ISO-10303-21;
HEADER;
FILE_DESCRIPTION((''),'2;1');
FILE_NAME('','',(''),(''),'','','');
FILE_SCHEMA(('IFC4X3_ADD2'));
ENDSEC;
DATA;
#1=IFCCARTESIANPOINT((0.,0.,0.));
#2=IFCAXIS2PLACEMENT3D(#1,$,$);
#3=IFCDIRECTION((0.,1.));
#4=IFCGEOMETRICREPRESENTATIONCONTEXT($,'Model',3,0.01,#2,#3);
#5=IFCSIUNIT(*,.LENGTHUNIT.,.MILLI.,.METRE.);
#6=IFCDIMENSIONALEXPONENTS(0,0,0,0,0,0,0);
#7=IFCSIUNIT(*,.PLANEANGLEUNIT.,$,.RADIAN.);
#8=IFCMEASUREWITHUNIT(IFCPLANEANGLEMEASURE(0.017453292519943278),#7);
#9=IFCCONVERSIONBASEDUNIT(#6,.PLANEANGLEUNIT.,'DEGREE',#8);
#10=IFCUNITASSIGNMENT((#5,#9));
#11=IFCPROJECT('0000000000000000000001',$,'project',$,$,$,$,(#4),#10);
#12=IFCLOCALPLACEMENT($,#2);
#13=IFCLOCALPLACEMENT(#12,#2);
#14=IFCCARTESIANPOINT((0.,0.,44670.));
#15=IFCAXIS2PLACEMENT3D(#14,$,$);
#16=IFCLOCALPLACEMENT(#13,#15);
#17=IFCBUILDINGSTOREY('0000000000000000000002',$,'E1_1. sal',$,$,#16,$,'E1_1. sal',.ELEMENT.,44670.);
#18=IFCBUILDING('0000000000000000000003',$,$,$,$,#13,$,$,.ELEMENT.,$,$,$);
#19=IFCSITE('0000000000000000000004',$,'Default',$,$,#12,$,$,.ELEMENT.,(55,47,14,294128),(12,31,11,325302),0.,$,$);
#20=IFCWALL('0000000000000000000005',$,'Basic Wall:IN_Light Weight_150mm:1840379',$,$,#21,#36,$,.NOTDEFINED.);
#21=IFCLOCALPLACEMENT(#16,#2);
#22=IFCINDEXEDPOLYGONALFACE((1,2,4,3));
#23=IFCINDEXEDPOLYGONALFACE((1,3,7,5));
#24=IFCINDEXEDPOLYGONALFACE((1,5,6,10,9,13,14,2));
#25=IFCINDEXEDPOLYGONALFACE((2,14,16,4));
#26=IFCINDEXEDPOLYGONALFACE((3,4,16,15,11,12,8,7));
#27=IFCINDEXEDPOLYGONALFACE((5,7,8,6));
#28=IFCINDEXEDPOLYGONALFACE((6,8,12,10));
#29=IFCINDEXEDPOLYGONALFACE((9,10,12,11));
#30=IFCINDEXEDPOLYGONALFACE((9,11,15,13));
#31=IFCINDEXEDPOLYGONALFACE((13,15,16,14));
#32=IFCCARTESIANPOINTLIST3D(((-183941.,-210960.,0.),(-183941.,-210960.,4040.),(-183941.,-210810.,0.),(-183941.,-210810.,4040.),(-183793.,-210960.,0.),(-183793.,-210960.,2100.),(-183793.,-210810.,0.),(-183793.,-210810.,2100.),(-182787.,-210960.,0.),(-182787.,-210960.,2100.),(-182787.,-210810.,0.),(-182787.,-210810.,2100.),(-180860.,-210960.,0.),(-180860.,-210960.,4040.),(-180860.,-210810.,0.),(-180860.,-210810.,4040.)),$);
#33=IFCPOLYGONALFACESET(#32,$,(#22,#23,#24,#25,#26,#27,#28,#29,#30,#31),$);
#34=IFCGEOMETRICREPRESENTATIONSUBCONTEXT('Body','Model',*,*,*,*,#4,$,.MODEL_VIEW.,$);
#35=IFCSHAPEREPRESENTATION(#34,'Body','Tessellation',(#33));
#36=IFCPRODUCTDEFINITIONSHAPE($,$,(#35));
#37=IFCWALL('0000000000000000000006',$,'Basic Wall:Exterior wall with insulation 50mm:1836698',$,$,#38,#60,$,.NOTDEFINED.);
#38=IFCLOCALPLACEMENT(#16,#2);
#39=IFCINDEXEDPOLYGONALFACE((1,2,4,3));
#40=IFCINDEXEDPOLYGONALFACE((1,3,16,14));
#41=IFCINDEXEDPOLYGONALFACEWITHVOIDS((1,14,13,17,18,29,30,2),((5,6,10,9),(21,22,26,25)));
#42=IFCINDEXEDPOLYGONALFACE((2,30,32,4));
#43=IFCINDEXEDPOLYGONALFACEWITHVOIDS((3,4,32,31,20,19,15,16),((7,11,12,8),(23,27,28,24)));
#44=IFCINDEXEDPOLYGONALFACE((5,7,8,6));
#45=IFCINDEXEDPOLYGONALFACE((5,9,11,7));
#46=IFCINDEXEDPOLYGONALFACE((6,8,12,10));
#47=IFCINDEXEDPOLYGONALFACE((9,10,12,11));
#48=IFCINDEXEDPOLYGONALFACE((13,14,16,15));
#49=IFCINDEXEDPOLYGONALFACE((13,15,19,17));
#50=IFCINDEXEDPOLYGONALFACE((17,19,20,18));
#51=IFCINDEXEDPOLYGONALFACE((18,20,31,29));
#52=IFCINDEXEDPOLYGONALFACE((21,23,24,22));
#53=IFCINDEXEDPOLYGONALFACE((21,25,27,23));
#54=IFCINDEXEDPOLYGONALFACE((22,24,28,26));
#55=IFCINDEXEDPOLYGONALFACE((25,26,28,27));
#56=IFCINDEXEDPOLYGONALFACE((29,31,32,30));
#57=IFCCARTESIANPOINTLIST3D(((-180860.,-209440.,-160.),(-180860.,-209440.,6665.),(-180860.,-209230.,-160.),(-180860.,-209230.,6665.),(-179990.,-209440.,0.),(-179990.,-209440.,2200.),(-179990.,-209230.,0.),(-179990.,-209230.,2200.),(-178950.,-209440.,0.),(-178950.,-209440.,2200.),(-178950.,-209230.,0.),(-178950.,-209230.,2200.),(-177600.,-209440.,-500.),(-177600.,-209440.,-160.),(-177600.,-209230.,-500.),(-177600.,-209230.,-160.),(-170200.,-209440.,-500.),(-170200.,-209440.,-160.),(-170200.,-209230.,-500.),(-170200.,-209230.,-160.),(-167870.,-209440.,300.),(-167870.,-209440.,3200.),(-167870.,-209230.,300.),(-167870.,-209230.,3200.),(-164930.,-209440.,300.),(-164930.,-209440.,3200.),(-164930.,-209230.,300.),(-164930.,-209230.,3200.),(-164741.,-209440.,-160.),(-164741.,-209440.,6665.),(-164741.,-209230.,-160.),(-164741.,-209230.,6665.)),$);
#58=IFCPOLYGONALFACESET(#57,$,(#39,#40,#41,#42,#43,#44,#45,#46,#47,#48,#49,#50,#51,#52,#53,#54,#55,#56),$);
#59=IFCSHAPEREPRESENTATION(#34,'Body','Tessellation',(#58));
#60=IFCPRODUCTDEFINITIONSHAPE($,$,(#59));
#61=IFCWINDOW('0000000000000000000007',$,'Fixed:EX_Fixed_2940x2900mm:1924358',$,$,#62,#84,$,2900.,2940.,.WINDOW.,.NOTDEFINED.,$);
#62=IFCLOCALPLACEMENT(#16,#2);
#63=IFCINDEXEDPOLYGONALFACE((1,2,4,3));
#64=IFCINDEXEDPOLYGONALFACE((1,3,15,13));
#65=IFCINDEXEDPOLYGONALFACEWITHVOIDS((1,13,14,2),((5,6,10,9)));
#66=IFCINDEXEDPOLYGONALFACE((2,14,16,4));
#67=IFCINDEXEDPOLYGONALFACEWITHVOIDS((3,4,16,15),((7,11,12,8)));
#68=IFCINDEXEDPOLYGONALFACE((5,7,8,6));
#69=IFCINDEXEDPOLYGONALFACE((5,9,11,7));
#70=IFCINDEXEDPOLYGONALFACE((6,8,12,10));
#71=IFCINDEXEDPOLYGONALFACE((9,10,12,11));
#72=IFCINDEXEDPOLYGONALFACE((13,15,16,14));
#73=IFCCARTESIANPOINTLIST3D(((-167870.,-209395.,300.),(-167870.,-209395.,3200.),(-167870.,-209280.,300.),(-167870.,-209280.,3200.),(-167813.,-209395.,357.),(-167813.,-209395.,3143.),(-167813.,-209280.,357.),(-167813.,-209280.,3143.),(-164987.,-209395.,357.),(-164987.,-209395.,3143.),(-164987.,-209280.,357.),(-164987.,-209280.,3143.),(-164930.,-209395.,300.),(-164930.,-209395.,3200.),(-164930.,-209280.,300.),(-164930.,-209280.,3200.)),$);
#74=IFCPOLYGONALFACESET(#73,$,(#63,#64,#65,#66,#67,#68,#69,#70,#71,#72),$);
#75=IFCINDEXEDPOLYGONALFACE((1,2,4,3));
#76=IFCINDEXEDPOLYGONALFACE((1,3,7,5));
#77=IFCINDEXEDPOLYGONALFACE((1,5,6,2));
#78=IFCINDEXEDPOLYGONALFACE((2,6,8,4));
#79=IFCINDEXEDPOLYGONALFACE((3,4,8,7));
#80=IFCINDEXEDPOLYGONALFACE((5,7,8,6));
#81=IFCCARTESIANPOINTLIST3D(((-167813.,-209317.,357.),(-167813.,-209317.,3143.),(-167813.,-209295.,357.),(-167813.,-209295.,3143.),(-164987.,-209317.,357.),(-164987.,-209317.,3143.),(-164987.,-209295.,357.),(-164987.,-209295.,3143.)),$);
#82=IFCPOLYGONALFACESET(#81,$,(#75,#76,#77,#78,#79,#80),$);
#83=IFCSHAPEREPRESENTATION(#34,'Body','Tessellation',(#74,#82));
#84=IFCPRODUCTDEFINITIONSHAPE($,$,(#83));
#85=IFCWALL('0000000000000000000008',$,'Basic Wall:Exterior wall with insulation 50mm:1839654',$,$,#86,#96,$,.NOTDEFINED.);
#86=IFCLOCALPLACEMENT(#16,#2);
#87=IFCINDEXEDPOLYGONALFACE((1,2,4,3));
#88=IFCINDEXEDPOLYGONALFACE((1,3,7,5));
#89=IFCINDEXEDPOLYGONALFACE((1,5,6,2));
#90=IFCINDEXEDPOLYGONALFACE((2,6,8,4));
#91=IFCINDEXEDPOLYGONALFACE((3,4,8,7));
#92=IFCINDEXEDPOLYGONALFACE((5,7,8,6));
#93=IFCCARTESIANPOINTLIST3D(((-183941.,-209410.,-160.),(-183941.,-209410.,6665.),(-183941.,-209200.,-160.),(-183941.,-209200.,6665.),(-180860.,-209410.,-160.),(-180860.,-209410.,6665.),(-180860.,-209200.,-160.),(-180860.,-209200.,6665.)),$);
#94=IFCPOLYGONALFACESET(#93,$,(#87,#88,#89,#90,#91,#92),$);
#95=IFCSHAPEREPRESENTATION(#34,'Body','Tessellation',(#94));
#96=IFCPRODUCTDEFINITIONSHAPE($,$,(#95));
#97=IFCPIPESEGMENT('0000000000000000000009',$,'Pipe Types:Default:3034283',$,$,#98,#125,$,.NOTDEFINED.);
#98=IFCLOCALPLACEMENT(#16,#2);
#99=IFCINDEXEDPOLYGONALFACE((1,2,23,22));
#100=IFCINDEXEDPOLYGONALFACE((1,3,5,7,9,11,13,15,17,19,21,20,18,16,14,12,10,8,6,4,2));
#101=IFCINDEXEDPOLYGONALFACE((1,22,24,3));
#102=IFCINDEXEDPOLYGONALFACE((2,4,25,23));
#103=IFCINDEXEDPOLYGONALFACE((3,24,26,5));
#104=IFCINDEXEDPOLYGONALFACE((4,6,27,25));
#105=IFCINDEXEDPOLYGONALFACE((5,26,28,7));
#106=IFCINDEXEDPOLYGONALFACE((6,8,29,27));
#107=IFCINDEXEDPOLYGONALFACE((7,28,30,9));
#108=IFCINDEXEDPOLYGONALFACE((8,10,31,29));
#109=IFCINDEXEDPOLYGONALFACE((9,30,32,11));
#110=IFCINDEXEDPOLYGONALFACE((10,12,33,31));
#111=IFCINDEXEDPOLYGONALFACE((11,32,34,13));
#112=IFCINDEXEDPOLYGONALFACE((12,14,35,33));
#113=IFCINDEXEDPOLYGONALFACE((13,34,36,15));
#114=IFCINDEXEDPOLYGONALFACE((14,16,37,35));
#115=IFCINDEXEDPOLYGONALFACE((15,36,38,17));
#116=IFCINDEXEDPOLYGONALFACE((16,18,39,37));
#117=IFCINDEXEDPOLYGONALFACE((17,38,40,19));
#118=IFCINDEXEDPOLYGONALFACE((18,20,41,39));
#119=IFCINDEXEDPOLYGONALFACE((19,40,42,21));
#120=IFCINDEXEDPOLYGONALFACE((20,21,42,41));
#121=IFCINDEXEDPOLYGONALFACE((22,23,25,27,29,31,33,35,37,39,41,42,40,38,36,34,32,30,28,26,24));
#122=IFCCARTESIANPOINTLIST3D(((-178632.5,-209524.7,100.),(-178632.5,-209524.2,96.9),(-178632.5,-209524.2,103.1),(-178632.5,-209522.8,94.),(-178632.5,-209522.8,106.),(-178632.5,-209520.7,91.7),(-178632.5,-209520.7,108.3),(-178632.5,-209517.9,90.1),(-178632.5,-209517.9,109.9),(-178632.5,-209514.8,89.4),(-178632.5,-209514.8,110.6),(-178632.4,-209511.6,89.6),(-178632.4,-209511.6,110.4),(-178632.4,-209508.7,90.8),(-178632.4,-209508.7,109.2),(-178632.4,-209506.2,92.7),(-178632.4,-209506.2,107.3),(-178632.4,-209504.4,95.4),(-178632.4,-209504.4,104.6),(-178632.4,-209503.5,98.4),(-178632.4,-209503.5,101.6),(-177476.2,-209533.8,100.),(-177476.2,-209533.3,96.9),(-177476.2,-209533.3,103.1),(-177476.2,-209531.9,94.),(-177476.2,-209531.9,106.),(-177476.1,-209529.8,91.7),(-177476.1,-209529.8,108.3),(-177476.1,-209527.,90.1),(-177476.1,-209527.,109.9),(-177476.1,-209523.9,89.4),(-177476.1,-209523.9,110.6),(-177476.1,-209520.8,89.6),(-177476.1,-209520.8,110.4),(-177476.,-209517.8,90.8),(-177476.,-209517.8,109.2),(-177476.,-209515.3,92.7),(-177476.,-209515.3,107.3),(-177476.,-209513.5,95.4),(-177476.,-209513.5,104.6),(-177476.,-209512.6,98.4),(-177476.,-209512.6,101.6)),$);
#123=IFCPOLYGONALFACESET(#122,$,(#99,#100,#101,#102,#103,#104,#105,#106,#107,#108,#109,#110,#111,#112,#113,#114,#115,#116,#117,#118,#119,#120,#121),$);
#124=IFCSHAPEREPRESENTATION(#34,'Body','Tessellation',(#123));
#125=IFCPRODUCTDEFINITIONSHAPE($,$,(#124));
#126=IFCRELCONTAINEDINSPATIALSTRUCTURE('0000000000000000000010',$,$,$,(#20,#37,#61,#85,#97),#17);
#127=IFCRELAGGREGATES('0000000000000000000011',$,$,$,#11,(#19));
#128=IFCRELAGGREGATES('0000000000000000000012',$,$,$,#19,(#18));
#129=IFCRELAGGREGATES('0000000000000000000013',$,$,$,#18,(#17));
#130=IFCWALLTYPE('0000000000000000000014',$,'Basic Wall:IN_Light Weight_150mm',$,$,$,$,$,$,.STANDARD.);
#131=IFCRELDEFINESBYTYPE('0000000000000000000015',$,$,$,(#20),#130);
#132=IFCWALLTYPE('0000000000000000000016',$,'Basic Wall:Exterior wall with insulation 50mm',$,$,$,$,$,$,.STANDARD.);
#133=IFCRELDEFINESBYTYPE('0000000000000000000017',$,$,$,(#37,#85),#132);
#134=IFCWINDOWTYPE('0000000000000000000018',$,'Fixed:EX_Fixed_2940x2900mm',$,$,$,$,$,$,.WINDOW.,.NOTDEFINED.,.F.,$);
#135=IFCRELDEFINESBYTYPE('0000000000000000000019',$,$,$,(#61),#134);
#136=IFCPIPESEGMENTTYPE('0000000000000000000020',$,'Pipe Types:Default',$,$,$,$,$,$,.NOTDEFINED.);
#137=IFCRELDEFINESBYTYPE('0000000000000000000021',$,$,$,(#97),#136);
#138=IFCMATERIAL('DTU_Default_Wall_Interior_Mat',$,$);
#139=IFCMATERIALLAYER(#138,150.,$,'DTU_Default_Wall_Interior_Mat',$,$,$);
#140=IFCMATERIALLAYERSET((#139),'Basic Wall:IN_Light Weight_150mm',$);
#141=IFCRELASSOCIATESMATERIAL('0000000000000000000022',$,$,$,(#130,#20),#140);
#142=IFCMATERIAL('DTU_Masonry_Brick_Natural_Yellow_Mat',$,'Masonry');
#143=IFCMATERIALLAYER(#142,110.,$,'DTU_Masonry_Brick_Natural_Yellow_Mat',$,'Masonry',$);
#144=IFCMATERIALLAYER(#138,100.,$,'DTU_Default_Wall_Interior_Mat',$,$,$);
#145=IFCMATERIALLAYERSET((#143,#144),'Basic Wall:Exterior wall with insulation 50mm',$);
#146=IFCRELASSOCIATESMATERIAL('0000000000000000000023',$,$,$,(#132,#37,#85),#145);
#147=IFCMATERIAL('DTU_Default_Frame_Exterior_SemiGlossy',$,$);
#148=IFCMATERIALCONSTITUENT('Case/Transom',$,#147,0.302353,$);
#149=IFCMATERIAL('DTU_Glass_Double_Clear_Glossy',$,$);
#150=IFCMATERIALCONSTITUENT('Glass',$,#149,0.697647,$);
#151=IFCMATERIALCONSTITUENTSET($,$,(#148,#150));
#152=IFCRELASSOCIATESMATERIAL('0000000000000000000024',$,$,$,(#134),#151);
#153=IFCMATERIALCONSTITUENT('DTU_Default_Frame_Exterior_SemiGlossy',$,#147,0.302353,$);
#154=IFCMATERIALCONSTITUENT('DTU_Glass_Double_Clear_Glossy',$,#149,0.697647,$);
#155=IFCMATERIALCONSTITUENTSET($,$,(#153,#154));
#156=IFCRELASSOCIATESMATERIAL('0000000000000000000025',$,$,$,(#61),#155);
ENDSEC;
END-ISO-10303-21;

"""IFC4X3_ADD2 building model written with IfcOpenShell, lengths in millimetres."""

from ifc_helpers import new_model, entity, si_unit, converted_unit, direction, frame, frame_2d, origin, place, context, subcontext, project, spatial, polyline, rectangle, circle, outline, extrude, source, transform, mapped, material, layer, layer_set, constituent, constituent_set, type_object, type_shapes, element, fill, save


model = new_model("IFC4X3_ADD2")

# Units and contexts
model_context = context("Model", 3, precision=0.01, world=origin(), true_north=direction((0.0, 1.0)))
body_context = subcontext(model_context, "Body", "Model", "MODEL_VIEW")
ifc_project = project(units=[si_unit("LENGTHUNIT", "METRE", prefix="MILLI"), converted_unit("PLANEANGLEUNIT", "DEGREE", entity("IfcPlaneAngleMeasure", 0.017453292519943278), si_unit("PLANEANGLEUNIT", "RADIAN"), dimensions=[0, 0, 0, 0, 0, 0, 0])], contexts=[model_context])

# Site, building, storey
site_placement = place(None, origin())
site = spatial("IfcSite", under=ifc_project, at=site_placement, Name="Default", CompositionType="ELEMENT", RefLatitude=(55, 47, 14, 294128), RefLongitude=(12, 31, 11, 325302), RefElevation=0.0)
building_placement = place(site_placement, origin())
building = spatial("IfcBuilding", under=site, at=building_placement, CompositionType="ELEMENT")
storey_placement = place(building_placement, frame((0.0, 0.0, 44670.0)))
storey = spatial("IfcBuildingStorey", under=building, at=storey_placement, Name="E1_1. sal", LongName="E1_1. sal", CompositionType="ELEMENT", Elevation=44670.0)

# Wall, opening
ifc_material_1 = material(Name="DTU_Default_Wall_Interior_Mat")
ifc_layer_1 = layer(ifc_material_1, 150.0, Name="DTU_Default_Wall_Interior_Mat")
ifc_layer_set_1 = layer_set([ifc_layer_1], Name="Basic Wall:IN_Light Weight_150mm")
wall_type_1 = type_object("IfcWallType", Name="Basic Wall:IN_Light Weight_150mm", PredefinedType="STANDARD", material=ifc_layer_set_1)
wall_1_placement = place(storey_placement, frame((-183941.0, -210885.0, 0.0)))
wall_1 = element("IfcWall", 1, at=wall_1_placement, inside=storey, type_object=wall_type_1, material=ifc_layer_set_1, Name="Basic Wall:IN_Light Weight_150mm:1840379", PredefinedType="NOTDEFINED", context=body_context, shape_type="SweptSolid", body=[
    extrude(rectangle(XDim=3081.0, YDim=150.0, at=frame_2d((1540.5, 0.0), x_axis=(1.0, 0.0))), origin(), (0.0, 0.0, 1.0), 4040.0),
])
opening_1_placement = place(wall_1_placement, frame((1154.0, 75.0, 0.0)))
element("IfcOpeningElement", 2, at=opening_1_placement, cuts=wall_1, PredefinedType="OPENING", context=body_context, shape_type="SweptSolid", body=[
    extrude(rectangle(XDim=2100.0, YDim=1006.0, at=frame_2d((1050.0, 503.0), x_axis=(1.0, 0.0))), frame((0.0, 0.0, 0.0), z_axis=(0.0, -1.0, 0.0), x_axis=(0.0, 0.0, 1.0)), (0.0, 0.0, 1.0), 150.0),
])

# Wall, openings, window
ifc_material_2 = material(Name="DTU_Masonry_Brick_Natural_Yellow_Mat", Category="Masonry")
ifc_layer_2 = layer(ifc_material_2, 110.0, Name="DTU_Masonry_Brick_Natural_Yellow_Mat", Category="Masonry")
ifc_layer_3 = layer(ifc_material_1, 100.0, Name="DTU_Default_Wall_Interior_Mat")
ifc_layer_set_2 = layer_set([ifc_layer_2, ifc_layer_3], Name="Basic Wall:Exterior wall with insulation 50mm")
wall_type_2 = type_object("IfcWallType", Name="Basic Wall:Exterior wall with insulation 50mm", PredefinedType="STANDARD", material=ifc_layer_set_2)
wall_2_placement = place(storey_placement, frame((-180860.0, -209335.0, -500.0)))
wall_2 = element("IfcWall", 3, at=wall_2_placement, inside=storey, type_object=wall_type_2, material=ifc_layer_set_2, Name="Basic Wall:Exterior wall with insulation 50mm:1836698", PredefinedType="NOTDEFINED", context=body_context, shape_type="SweptSolid", body=[
    extrude(rectangle(XDim=16119.0, YDim=210.0, at=frame_2d((8059.5, 0.0), x_axis=(-1.0, 0.0))), origin(), (0.0, 0.0, 1.0), 7165.0),
])
opening_2_placement = place(wall_2_placement, origin())
element("IfcOpeningElement", 4, at=opening_2_placement, cuts=wall_2, PredefinedType="OPENING", context=body_context, shape_type="SweptSolid", body=[
    extrude(rectangle(XDim=340.0, YDim=5459.0, at=frame_2d((0.0, 0.0), x_axis=(0.0, 1.0))), frame((13389.5, 105.0, 170.0), z_axis=(0.0, -1.0, 0.0), x_axis=(1.0, 0.0, 0.0)), (0.0, 0.0, 1.0), 210.0),
])
opening_3_placement = place(wall_2_placement, origin())
element("IfcOpeningElement", 5, at=opening_3_placement, cuts=wall_2, PredefinedType="OPENING", context=body_context, shape_type="SweptSolid", body=[
    extrude(rectangle(XDim=340.0, YDim=3260.0, at=frame_2d((0.0, 0.0), x_axis=(1.0, 0.0))), frame((1630.0, 105.0, 170.0), z_axis=(0.0, -1.0, 0.0), x_axis=(0.0, 0.0, -1.0)), (0.0, 0.0, 1.0), 210.0),
])
opening_4_placement = place(wall_2_placement, frame((870.0, -105.0, 500.0)))
element("IfcOpeningElement", 6, at=opening_4_placement, cuts=wall_2, PredefinedType="OPENING", context=body_context, shape_type="SweptSolid", body=[
    extrude(rectangle(XDim=2200.0, YDim=1040.0, at=frame_2d((1100.0, 520.0), x_axis=(1.0, 0.0))), frame((0.0, 0.0, 0.0), z_axis=(0.0, 1.0, 0.0), x_axis=(0.0, 0.0, 1.0)), (0.0, 0.0, 1.0), 210.0),
])
opening_5_placement = place(wall_2_placement, frame((12990.0, -105.0, 800.0)))
opening_5 = element("IfcOpeningElement", 7, at=opening_5_placement, cuts=wall_2, PredefinedType="OPENING", context=body_context, shape_type="SweptSolid", body=[
    extrude(rectangle(XDim=2900.0, YDim=2940.0, at=frame_2d((1450.0, 1470.0), x_axis=(1.0, 0.0))), frame((0.0, 0.0, 0.0), z_axis=(0.0, 1.0, 0.0), x_axis=(0.0, 0.0, 1.0)), (0.0, 0.0, 1.0), 210.0),
])
ifc_material_3 = material(Name="DTU_Default_Frame_Exterior_SemiGlossy")
ifc_constituent_1 = constituent(ifc_material_3, Name="DTU_Default_Frame_Exterior_SemiGlossy", fraction=0.302353)
ifc_material_4 = material(Name="DTU_Glass_Double_Clear_Glossy")
ifc_constituent_2 = constituent(ifc_material_4, Name="DTU_Glass_Double_Clear_Glossy", fraction=0.697647)
ifc_constituent_set_1 = constituent_set(constituents=[ifc_constituent_1, ifc_constituent_2])
ifc_constituent_3 = constituent(ifc_material_3, Name="Case/Transom", fraction=0.302353)
ifc_constituent_4 = constituent(ifc_material_4, Name="Glass", fraction=0.697647)
ifc_constituent_set_2 = constituent_set(constituents=[ifc_constituent_3, ifc_constituent_4])
window_type = type_object("IfcWindowType", Name="Fixed:EX_Fixed_2940x2900mm", ParameterTakesPrecedence=False, PartitioningType="NOTDEFINED", PredefinedType="WINDOW", material=ifc_constituent_set_2)
shared_shape_1 = source(origin(), body_context, "Body", "SweptSolid", [
    extrude(outline(polyline([(-1470.0, -1450.0), (1470.0, -1450.0), (1470.0, 1450.0), (-1470.0, 1450.0), (-1470.0, -1450.0)]), holes=[polyline([(-1413.0, 1393.0), (1413.0, 1393.0), (1413.0, -1393.0), (-1413.0, -1393.0), (-1413.0, 1393.0)])]), frame((1470.0, 160.0, 1450.0), z_axis=(0.0, -1.0, 0.0), x_axis=(1.0, 0.0, 0.0)), (0.0, 0.0, 1.0), 115.0),
    extrude(rectangle(XDim=2826.0, YDim=22.0, at=frame_2d((0.0, 0.0), x_axis=(1.0, 0.0))), frame((1470.0, 134.0, 57.0), z_axis=(0.0, 0.0, 1.0), x_axis=(-1.0, 0.0, 0.0)), (0.0, 0.0, 1.0), 2786.0),
])
type_shapes(window_type, [shared_shape_1])
window_placement = place(opening_5_placement, origin())
window = element("IfcWindow", 8, at=window_placement, inside=storey, type_object=window_type, material=ifc_constituent_set_1, Name="Fixed:EX_Fixed_2940x2900mm:1924358", OverallHeight=2900.0, OverallWidth=2940.0, PartitioningType="NOTDEFINED", PredefinedType="WINDOW", context=body_context, shape_type="MappedRepresentation", body=[
    mapped(shared_shape_1, transform((0.0, 0.0, 0.0), scale=1.0)),
])
fill(opening_5, window)

# Wall
wall_3_placement = place(storey_placement, frame((-183941.0, -209305.0, -160.0)))
element("IfcWall", 9, at=wall_3_placement, inside=storey, type_object=wall_type_2, material=ifc_layer_set_2, Name="Basic Wall:Exterior wall with insulation 50mm:1839654", PredefinedType="NOTDEFINED", context=body_context, shape_type="SweptSolid", body=[
    extrude(rectangle(XDim=3081.0, YDim=210.0, at=frame_2d((1540.5, 0.0), x_axis=(-1.0, 0.0))), origin(), (0.0, 0.0, 1.0), 6825.0),
])

# Pipe segment
pipe_segment_type = type_object("IfcPipeSegmentType", Name="Pipe Types:Default", PredefinedType="NOTDEFINED")
pipe_segment_1_placement = place(storey_placement, frame((-178632.5, -209535.4, 87.7)))
element("IfcPipeSegment", 10, at=pipe_segment_1_placement, inside=storey, type_object=pipe_segment_type, Name="Pipe Types:Default:3034283", PredefinedType="NOTDEFINED", context=body_context, shape_type="SweptSolid", body=[
    extrude(circle(Radius=10.7, at=frame_2d((0.0, 0.0), x_axis=(1.0, 0.0))), frame((1156.5, 12.3, 12.3), z_axis=(-0.999969, 0.007895, 0.0), x_axis=(-0.007895, -0.999969, 0.0)), (0.0, 0.0, 1.0), 1156.4),
])

save(model, "model.ifc")
